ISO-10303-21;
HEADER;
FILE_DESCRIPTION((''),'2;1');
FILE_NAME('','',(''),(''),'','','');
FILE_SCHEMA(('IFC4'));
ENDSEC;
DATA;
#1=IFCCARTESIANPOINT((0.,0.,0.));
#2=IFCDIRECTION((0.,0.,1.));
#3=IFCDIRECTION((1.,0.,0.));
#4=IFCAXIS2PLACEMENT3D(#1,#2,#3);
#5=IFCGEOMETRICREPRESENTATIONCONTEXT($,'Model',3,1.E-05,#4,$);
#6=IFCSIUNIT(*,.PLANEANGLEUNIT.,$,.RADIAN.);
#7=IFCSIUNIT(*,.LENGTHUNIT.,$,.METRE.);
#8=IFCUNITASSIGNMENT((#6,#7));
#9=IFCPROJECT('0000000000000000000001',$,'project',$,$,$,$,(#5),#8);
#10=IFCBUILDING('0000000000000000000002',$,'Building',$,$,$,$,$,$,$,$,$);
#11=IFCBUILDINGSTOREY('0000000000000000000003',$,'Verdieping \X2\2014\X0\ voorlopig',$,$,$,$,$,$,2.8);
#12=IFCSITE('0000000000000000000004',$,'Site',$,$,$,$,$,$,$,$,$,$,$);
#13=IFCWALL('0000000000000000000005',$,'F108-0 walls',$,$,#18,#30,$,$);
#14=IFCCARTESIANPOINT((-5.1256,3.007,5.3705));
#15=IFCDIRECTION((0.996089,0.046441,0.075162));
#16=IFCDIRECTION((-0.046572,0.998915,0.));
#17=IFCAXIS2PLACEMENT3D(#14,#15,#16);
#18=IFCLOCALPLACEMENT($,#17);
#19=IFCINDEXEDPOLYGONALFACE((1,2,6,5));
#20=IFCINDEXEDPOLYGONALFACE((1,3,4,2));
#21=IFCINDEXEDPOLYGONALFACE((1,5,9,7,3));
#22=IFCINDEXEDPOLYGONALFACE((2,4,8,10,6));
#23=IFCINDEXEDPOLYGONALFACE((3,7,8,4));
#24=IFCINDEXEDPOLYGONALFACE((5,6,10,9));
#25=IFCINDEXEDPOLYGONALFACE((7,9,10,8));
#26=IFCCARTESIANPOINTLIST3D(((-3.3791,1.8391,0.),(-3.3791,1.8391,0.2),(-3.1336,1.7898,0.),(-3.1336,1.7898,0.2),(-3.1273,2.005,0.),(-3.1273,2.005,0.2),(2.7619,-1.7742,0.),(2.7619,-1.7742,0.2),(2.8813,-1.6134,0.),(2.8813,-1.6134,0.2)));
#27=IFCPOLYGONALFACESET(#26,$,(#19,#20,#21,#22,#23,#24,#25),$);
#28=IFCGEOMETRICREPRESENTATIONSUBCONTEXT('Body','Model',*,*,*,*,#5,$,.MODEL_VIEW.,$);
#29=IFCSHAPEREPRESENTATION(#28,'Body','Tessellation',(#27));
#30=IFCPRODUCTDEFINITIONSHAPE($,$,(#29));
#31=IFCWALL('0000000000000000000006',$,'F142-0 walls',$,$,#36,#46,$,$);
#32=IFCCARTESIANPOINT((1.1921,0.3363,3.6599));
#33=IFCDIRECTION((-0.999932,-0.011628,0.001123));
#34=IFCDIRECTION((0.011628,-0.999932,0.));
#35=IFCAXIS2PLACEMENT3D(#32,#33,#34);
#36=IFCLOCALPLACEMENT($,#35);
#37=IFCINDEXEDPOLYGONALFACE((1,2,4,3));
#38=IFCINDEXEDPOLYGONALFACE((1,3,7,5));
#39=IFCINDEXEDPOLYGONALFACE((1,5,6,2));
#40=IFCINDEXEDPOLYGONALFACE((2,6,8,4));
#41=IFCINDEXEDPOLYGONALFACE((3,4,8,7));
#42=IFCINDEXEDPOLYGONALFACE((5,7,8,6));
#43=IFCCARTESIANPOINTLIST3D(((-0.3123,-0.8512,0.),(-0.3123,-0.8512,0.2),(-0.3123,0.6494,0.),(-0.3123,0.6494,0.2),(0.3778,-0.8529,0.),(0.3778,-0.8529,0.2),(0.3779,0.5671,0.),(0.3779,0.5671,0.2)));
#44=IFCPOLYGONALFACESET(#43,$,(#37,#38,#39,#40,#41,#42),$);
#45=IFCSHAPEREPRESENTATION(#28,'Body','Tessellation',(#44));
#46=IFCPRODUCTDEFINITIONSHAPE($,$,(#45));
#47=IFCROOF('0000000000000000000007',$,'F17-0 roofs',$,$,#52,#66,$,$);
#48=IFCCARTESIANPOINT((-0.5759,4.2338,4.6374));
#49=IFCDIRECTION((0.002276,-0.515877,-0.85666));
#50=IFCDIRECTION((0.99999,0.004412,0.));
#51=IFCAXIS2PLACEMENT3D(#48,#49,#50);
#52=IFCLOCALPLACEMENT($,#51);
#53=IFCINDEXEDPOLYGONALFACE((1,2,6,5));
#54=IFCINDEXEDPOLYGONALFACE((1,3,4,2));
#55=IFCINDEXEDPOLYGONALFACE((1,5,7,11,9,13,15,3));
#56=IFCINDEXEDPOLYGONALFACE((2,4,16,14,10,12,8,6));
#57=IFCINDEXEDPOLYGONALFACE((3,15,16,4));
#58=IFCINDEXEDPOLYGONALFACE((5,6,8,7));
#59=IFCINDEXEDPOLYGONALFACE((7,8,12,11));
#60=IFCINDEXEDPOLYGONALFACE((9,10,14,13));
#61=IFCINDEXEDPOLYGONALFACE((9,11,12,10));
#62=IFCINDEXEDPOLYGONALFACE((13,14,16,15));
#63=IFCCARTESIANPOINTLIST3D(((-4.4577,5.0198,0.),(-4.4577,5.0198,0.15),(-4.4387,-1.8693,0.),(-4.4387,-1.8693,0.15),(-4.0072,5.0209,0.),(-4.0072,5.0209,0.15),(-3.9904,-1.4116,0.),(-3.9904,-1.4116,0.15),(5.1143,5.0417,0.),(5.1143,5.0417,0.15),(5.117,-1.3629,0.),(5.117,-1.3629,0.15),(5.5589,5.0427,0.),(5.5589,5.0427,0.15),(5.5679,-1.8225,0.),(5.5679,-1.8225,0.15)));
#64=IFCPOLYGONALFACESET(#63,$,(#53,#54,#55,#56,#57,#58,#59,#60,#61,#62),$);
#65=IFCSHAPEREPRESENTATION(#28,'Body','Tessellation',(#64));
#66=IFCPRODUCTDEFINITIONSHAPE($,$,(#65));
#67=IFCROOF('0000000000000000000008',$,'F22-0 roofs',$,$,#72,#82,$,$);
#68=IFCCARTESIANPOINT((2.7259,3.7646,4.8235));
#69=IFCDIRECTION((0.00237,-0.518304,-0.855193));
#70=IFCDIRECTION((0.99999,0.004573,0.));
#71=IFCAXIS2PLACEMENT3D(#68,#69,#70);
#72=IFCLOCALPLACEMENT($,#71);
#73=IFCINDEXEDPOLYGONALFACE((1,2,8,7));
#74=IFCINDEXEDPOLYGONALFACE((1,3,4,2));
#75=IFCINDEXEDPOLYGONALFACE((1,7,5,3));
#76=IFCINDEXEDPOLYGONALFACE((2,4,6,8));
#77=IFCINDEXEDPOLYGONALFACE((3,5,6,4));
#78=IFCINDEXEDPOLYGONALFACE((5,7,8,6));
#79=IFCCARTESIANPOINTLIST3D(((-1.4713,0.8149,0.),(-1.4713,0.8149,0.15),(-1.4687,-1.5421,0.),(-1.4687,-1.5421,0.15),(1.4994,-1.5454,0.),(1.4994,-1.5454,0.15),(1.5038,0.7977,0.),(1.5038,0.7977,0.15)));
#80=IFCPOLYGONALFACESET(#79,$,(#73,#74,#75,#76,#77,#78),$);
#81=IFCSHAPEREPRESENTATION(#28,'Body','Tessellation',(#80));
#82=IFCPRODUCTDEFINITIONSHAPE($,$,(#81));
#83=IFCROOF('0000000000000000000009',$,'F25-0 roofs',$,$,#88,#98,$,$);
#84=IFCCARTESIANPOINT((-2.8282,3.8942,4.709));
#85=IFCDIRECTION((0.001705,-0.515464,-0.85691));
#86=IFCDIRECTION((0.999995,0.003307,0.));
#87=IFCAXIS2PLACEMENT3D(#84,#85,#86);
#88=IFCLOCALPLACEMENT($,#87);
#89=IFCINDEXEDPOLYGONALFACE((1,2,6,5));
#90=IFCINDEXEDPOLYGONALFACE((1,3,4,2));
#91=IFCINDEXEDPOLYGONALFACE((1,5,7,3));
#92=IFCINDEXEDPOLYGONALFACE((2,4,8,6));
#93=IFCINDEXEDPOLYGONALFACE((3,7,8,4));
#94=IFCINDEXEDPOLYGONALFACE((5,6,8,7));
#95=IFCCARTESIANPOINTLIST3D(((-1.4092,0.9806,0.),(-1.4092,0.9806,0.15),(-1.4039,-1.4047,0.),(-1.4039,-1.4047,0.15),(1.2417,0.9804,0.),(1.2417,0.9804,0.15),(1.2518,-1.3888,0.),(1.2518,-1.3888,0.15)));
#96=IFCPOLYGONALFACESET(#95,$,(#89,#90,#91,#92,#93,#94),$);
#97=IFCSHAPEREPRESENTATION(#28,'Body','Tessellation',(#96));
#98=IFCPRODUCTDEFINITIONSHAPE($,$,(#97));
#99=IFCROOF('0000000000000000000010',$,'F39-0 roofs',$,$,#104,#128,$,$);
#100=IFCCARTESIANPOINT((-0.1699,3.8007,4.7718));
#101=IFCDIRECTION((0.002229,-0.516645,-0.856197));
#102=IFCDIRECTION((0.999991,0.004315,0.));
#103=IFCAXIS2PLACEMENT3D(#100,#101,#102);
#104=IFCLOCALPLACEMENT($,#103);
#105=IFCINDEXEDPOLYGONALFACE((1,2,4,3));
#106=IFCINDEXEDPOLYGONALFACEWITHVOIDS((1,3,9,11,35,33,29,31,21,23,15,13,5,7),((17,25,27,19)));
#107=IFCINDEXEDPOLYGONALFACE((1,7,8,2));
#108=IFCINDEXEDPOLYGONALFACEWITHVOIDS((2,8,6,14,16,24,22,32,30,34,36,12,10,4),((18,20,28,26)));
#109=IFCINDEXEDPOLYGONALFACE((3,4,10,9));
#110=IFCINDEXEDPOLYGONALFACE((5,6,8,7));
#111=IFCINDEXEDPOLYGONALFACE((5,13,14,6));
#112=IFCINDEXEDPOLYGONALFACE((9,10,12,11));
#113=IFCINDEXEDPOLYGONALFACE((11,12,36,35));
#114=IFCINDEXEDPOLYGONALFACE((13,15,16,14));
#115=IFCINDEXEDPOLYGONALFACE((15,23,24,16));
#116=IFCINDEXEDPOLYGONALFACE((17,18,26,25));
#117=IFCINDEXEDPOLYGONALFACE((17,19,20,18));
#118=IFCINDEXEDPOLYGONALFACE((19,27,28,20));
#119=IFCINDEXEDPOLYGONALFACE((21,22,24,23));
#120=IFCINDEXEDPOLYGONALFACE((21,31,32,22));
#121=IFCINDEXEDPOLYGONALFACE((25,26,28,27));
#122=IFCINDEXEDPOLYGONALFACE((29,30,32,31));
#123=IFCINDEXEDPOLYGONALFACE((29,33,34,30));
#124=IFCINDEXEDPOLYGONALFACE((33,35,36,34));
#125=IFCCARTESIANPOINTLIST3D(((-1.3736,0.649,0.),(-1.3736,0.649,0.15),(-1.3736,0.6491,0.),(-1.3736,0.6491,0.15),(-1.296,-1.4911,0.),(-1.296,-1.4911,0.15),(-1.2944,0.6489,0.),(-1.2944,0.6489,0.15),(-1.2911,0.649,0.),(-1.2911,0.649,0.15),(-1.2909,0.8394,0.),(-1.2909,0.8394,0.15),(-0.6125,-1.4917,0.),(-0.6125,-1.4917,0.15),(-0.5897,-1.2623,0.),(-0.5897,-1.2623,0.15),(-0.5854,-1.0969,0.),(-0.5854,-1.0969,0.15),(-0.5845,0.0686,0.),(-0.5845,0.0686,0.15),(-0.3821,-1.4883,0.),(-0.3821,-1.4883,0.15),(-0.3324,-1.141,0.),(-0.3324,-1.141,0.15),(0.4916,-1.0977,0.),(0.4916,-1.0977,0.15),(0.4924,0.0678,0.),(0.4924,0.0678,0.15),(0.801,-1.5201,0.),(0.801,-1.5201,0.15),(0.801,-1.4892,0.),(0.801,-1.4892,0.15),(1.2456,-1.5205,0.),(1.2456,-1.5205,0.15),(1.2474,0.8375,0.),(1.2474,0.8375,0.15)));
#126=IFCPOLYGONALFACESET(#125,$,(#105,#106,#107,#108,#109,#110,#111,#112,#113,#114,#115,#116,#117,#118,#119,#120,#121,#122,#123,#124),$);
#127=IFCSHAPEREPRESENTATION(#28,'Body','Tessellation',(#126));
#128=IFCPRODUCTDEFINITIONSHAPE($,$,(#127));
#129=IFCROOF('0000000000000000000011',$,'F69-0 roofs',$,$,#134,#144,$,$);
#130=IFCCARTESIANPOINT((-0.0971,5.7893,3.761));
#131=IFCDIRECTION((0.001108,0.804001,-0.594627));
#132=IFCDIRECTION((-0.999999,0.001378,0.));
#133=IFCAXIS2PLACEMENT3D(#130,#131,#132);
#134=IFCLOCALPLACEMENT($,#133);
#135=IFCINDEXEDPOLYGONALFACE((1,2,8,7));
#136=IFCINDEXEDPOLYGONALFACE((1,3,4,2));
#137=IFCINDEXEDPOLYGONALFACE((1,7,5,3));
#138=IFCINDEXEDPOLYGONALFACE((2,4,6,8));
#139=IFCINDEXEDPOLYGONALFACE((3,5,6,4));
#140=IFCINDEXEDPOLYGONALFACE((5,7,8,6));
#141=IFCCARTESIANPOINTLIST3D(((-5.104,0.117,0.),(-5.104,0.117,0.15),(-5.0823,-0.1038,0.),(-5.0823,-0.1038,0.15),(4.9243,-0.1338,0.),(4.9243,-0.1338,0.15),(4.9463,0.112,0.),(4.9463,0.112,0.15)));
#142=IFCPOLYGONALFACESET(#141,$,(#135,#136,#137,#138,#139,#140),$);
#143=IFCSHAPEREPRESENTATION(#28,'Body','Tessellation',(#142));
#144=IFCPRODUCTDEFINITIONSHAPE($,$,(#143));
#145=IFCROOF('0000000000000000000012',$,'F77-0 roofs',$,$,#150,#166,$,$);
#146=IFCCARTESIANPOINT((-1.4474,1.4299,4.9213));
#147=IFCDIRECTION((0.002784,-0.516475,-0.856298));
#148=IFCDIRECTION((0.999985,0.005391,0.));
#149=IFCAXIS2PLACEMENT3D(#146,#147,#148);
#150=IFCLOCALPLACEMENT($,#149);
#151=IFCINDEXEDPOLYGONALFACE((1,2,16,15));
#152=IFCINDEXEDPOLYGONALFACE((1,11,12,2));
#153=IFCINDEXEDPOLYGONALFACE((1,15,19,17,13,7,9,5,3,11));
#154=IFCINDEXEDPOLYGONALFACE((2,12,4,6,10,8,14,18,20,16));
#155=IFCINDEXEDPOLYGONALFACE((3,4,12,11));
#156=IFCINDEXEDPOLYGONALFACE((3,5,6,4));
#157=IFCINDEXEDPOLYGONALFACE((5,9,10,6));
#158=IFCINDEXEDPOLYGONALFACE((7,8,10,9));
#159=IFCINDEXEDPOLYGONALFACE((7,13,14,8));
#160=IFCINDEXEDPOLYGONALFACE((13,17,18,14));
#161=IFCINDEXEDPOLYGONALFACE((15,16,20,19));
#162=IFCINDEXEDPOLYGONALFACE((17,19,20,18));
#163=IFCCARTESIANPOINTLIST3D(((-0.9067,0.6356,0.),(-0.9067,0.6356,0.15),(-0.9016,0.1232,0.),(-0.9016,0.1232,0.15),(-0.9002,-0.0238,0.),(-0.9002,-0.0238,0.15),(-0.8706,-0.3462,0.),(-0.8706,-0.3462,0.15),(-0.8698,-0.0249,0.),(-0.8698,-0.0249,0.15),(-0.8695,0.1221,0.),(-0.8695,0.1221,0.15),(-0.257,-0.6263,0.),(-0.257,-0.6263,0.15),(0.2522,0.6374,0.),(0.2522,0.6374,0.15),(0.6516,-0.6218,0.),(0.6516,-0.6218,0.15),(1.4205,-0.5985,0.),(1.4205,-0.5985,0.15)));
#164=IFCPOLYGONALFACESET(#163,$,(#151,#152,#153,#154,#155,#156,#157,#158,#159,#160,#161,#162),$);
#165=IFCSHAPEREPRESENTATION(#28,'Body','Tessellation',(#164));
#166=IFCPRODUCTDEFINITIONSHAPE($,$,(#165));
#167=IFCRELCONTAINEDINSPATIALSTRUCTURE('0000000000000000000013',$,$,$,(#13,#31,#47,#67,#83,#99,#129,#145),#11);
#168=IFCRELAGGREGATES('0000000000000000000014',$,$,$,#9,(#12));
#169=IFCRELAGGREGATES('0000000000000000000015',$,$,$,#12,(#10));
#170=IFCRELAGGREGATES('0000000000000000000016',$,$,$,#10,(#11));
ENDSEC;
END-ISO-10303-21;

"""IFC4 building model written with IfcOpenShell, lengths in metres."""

from ifc_helpers import new_model, si_unit, frame, origin_with_axes, place, context, subcontext, project, spatial, polyline, outline, extrude, element, save


model = new_model("IFC4")

# Units and contexts
model_context = context("Model", 3, precision=1e-05, world=origin_with_axes())
body_context = subcontext(model_context, "Body", "Model", "MODEL_VIEW")
ifc_project = project(units=[si_unit("PLANEANGLEUNIT", "RADIAN"), si_unit("LENGTHUNIT", "METRE")], contexts=[model_context])

# Site, building, storey
site = spatial("IfcSite", under=ifc_project, Name="Site")
building = spatial("IfcBuilding", under=site, Name="Building")
storey = spatial("IfcBuildingStorey", under=building, Name="Verdieping — voorlopig", Elevation=2.8)

# Walls
wall_1_placement = place(None, frame((-5.1256, 3.007, 5.3705), z_axis=(0.996089, 0.046441, 0.075162), x_axis=(-0.046572, 0.998915, 0.0)))
element("IfcWall", 1, at=wall_1_placement, inside=storey, Name="F108-0 walls", context=body_context, shape_type="SweptSolid", body=[
    extrude(outline(polyline([(2.7619, -1.7742), (2.8813, -1.6134), (-3.1273, 2.005), (-3.3791, 1.8391), (-3.1336, 1.7898), (2.7619, -1.7742)])), origin_with_axes(), (0.0, 0.0, 1.0), 0.2),
])
wall_2_placement = place(None, frame((1.1921, 0.3363, 3.6599), z_axis=(-0.999932, -0.011628, 0.001123), x_axis=(0.011628, -0.999932, 0.0)))
element("IfcWall", 2, at=wall_2_placement, inside=storey, Name="F142-0 walls", context=body_context, shape_type="SweptSolid", body=[
    extrude(outline(polyline([(-0.3123, -0.8512), (0.3778, -0.8529), (0.3779, 0.5671), (-0.3123, 0.6494), (-0.3123, -0.8512)])), origin_with_axes(), (0.0, 0.0, 1.0), 0.2),
])

# Roofs
roof_1_placement = place(None, frame((-0.5759, 4.2338, 4.6374), z_axis=(0.002276, -0.515877, -0.85666), x_axis=(0.99999, 0.004412, 0.0)))
element("IfcRoof", 3, at=roof_1_placement, inside=storey, Name="F17-0 roofs", context=body_context, shape_type="SweptSolid", body=[
    extrude(outline(polyline([(-4.4387, -1.8693), (5.5679, -1.8225), (5.5589, 5.0427), (5.1143, 5.0417), (5.117, -1.3629), (-3.9904, -1.4116), (-4.0072, 5.0209), (-4.4577, 5.0198), (-4.4387, -1.8693)])), origin_with_axes(), (0.0, 0.0, 1.0), 0.15),
])
roof_2_placement = place(None, frame((2.7259, 3.7646, 4.8235), z_axis=(0.00237, -0.518304, -0.855193), x_axis=(0.99999, 0.004573, 0.0)))
element("IfcRoof", 4, at=roof_2_placement, inside=storey, Name="F22-0 roofs", context=body_context, shape_type="SweptSolid", body=[
    extrude(outline(polyline([(1.4994, -1.5454), (1.5038, 0.7977), (-1.4713, 0.8149), (-1.4687, -1.5421), (1.4994, -1.5454)])), origin_with_axes(), (0.0, 0.0, 1.0), 0.15),
])
roof_3_placement = place(None, frame((-2.8282, 3.8942, 4.709), z_axis=(0.001705, -0.515464, -0.85691), x_axis=(0.999995, 0.003307, 0.0)))
element("IfcRoof", 5, at=roof_3_placement, inside=storey, Name="F25-0 roofs", context=body_context, shape_type="SweptSolid", body=[
    extrude(outline(polyline([(1.2518, -1.3888), (1.2417, 0.9804), (-1.4092, 0.9806), (-1.4039, -1.4047), (1.2518, -1.3888)])), origin_with_axes(), (0.0, 0.0, 1.0), 0.15),
])

# Roof, opening
roof_4_placement = place(None, frame((-0.1699, 3.8007, 4.7718), z_axis=(0.002229, -0.516645, -0.856197), x_axis=(0.999991, 0.004315, 0.0)))
roof_4 = element("IfcRoof", 6, at=roof_4_placement, inside=storey, Name="F39-0 roofs", context=body_context, shape_type="SweptSolid", body=[
    extrude(outline(polyline([(0.801, -1.4892), (0.801, -1.5201), (1.2456, -1.5205), (1.2474, 0.8375), (-1.2909, 0.8394), (-1.2911, 0.649), (-1.3736, 0.6491), (-1.3736, 0.649), (-1.2944, 0.6489), (-1.296, -1.4911), (-0.6125, -1.4917), (-0.5897, -1.2623), (-0.3324, -1.141), (-0.3821, -1.4883), (0.801, -1.4892)])), origin_with_axes(), (0.0, 0.0, 1.0), 0.15),
])
opening_1_placement = place(roof_4_placement, frame((0.0, 0.0, -0.05), z_axis=(0.0, 0.0, 1.0), x_axis=(1.0, 0.0, 0.0)))
element("IfcOpeningElement", 7, at=opening_1_placement, cuts=roof_4, PredefinedType="OPENING", context=body_context, shape_type="SweptSolid", body=[
    extrude(outline(polyline([(-0.5854, -1.0969), (-0.5845, 0.0686), (0.4924, 0.0678), (0.4916, -1.0977), (-0.5854, -1.0969)])), origin_with_axes(), (0.0, 0.0, 1.0), 0.25),
])

# Roofs
roof_5_placement = place(None, frame((-0.0971, 5.7893, 3.761), z_axis=(0.001108, 0.804001, -0.594627), x_axis=(-0.999999, 0.001378, 0.0)))
element("IfcRoof", 8, at=roof_5_placement, inside=storey, Name="F69-0 roofs", context=body_context, shape_type="SweptSolid", body=[
    extrude(outline(polyline([(-5.0823, -0.1038), (4.9243, -0.1338), (4.9463, 0.112), (-5.104, 0.117), (-5.0823, -0.1038)])), origin_with_axes(), (0.0, 0.0, 1.0), 0.15),
])
roof_6_placement = place(None, frame((-1.4474, 1.4299, 4.9213), z_axis=(0.002784, -0.516475, -0.856298), x_axis=(0.999985, 0.005391, 0.0)))
element("IfcRoof", 9, at=roof_6_placement, inside=storey, Name="F77-0 roofs", context=body_context, shape_type="SweptSolid", body=[
    extrude(outline(polyline([(0.6516, -0.6218), (1.4205, -0.5985), (0.2522, 0.6374), (-0.9067, 0.6356), (-0.8695, 0.1221), (-0.9016, 0.1232), (-0.9002, -0.0238), (-0.8698, -0.0249), (-0.8706, -0.3462), (-0.257, -0.6263), (0.6516, -0.6218)])), origin_with_axes(), (0.0, 0.0, 1.0), 0.15),
])

save(model, "model.ifc")
